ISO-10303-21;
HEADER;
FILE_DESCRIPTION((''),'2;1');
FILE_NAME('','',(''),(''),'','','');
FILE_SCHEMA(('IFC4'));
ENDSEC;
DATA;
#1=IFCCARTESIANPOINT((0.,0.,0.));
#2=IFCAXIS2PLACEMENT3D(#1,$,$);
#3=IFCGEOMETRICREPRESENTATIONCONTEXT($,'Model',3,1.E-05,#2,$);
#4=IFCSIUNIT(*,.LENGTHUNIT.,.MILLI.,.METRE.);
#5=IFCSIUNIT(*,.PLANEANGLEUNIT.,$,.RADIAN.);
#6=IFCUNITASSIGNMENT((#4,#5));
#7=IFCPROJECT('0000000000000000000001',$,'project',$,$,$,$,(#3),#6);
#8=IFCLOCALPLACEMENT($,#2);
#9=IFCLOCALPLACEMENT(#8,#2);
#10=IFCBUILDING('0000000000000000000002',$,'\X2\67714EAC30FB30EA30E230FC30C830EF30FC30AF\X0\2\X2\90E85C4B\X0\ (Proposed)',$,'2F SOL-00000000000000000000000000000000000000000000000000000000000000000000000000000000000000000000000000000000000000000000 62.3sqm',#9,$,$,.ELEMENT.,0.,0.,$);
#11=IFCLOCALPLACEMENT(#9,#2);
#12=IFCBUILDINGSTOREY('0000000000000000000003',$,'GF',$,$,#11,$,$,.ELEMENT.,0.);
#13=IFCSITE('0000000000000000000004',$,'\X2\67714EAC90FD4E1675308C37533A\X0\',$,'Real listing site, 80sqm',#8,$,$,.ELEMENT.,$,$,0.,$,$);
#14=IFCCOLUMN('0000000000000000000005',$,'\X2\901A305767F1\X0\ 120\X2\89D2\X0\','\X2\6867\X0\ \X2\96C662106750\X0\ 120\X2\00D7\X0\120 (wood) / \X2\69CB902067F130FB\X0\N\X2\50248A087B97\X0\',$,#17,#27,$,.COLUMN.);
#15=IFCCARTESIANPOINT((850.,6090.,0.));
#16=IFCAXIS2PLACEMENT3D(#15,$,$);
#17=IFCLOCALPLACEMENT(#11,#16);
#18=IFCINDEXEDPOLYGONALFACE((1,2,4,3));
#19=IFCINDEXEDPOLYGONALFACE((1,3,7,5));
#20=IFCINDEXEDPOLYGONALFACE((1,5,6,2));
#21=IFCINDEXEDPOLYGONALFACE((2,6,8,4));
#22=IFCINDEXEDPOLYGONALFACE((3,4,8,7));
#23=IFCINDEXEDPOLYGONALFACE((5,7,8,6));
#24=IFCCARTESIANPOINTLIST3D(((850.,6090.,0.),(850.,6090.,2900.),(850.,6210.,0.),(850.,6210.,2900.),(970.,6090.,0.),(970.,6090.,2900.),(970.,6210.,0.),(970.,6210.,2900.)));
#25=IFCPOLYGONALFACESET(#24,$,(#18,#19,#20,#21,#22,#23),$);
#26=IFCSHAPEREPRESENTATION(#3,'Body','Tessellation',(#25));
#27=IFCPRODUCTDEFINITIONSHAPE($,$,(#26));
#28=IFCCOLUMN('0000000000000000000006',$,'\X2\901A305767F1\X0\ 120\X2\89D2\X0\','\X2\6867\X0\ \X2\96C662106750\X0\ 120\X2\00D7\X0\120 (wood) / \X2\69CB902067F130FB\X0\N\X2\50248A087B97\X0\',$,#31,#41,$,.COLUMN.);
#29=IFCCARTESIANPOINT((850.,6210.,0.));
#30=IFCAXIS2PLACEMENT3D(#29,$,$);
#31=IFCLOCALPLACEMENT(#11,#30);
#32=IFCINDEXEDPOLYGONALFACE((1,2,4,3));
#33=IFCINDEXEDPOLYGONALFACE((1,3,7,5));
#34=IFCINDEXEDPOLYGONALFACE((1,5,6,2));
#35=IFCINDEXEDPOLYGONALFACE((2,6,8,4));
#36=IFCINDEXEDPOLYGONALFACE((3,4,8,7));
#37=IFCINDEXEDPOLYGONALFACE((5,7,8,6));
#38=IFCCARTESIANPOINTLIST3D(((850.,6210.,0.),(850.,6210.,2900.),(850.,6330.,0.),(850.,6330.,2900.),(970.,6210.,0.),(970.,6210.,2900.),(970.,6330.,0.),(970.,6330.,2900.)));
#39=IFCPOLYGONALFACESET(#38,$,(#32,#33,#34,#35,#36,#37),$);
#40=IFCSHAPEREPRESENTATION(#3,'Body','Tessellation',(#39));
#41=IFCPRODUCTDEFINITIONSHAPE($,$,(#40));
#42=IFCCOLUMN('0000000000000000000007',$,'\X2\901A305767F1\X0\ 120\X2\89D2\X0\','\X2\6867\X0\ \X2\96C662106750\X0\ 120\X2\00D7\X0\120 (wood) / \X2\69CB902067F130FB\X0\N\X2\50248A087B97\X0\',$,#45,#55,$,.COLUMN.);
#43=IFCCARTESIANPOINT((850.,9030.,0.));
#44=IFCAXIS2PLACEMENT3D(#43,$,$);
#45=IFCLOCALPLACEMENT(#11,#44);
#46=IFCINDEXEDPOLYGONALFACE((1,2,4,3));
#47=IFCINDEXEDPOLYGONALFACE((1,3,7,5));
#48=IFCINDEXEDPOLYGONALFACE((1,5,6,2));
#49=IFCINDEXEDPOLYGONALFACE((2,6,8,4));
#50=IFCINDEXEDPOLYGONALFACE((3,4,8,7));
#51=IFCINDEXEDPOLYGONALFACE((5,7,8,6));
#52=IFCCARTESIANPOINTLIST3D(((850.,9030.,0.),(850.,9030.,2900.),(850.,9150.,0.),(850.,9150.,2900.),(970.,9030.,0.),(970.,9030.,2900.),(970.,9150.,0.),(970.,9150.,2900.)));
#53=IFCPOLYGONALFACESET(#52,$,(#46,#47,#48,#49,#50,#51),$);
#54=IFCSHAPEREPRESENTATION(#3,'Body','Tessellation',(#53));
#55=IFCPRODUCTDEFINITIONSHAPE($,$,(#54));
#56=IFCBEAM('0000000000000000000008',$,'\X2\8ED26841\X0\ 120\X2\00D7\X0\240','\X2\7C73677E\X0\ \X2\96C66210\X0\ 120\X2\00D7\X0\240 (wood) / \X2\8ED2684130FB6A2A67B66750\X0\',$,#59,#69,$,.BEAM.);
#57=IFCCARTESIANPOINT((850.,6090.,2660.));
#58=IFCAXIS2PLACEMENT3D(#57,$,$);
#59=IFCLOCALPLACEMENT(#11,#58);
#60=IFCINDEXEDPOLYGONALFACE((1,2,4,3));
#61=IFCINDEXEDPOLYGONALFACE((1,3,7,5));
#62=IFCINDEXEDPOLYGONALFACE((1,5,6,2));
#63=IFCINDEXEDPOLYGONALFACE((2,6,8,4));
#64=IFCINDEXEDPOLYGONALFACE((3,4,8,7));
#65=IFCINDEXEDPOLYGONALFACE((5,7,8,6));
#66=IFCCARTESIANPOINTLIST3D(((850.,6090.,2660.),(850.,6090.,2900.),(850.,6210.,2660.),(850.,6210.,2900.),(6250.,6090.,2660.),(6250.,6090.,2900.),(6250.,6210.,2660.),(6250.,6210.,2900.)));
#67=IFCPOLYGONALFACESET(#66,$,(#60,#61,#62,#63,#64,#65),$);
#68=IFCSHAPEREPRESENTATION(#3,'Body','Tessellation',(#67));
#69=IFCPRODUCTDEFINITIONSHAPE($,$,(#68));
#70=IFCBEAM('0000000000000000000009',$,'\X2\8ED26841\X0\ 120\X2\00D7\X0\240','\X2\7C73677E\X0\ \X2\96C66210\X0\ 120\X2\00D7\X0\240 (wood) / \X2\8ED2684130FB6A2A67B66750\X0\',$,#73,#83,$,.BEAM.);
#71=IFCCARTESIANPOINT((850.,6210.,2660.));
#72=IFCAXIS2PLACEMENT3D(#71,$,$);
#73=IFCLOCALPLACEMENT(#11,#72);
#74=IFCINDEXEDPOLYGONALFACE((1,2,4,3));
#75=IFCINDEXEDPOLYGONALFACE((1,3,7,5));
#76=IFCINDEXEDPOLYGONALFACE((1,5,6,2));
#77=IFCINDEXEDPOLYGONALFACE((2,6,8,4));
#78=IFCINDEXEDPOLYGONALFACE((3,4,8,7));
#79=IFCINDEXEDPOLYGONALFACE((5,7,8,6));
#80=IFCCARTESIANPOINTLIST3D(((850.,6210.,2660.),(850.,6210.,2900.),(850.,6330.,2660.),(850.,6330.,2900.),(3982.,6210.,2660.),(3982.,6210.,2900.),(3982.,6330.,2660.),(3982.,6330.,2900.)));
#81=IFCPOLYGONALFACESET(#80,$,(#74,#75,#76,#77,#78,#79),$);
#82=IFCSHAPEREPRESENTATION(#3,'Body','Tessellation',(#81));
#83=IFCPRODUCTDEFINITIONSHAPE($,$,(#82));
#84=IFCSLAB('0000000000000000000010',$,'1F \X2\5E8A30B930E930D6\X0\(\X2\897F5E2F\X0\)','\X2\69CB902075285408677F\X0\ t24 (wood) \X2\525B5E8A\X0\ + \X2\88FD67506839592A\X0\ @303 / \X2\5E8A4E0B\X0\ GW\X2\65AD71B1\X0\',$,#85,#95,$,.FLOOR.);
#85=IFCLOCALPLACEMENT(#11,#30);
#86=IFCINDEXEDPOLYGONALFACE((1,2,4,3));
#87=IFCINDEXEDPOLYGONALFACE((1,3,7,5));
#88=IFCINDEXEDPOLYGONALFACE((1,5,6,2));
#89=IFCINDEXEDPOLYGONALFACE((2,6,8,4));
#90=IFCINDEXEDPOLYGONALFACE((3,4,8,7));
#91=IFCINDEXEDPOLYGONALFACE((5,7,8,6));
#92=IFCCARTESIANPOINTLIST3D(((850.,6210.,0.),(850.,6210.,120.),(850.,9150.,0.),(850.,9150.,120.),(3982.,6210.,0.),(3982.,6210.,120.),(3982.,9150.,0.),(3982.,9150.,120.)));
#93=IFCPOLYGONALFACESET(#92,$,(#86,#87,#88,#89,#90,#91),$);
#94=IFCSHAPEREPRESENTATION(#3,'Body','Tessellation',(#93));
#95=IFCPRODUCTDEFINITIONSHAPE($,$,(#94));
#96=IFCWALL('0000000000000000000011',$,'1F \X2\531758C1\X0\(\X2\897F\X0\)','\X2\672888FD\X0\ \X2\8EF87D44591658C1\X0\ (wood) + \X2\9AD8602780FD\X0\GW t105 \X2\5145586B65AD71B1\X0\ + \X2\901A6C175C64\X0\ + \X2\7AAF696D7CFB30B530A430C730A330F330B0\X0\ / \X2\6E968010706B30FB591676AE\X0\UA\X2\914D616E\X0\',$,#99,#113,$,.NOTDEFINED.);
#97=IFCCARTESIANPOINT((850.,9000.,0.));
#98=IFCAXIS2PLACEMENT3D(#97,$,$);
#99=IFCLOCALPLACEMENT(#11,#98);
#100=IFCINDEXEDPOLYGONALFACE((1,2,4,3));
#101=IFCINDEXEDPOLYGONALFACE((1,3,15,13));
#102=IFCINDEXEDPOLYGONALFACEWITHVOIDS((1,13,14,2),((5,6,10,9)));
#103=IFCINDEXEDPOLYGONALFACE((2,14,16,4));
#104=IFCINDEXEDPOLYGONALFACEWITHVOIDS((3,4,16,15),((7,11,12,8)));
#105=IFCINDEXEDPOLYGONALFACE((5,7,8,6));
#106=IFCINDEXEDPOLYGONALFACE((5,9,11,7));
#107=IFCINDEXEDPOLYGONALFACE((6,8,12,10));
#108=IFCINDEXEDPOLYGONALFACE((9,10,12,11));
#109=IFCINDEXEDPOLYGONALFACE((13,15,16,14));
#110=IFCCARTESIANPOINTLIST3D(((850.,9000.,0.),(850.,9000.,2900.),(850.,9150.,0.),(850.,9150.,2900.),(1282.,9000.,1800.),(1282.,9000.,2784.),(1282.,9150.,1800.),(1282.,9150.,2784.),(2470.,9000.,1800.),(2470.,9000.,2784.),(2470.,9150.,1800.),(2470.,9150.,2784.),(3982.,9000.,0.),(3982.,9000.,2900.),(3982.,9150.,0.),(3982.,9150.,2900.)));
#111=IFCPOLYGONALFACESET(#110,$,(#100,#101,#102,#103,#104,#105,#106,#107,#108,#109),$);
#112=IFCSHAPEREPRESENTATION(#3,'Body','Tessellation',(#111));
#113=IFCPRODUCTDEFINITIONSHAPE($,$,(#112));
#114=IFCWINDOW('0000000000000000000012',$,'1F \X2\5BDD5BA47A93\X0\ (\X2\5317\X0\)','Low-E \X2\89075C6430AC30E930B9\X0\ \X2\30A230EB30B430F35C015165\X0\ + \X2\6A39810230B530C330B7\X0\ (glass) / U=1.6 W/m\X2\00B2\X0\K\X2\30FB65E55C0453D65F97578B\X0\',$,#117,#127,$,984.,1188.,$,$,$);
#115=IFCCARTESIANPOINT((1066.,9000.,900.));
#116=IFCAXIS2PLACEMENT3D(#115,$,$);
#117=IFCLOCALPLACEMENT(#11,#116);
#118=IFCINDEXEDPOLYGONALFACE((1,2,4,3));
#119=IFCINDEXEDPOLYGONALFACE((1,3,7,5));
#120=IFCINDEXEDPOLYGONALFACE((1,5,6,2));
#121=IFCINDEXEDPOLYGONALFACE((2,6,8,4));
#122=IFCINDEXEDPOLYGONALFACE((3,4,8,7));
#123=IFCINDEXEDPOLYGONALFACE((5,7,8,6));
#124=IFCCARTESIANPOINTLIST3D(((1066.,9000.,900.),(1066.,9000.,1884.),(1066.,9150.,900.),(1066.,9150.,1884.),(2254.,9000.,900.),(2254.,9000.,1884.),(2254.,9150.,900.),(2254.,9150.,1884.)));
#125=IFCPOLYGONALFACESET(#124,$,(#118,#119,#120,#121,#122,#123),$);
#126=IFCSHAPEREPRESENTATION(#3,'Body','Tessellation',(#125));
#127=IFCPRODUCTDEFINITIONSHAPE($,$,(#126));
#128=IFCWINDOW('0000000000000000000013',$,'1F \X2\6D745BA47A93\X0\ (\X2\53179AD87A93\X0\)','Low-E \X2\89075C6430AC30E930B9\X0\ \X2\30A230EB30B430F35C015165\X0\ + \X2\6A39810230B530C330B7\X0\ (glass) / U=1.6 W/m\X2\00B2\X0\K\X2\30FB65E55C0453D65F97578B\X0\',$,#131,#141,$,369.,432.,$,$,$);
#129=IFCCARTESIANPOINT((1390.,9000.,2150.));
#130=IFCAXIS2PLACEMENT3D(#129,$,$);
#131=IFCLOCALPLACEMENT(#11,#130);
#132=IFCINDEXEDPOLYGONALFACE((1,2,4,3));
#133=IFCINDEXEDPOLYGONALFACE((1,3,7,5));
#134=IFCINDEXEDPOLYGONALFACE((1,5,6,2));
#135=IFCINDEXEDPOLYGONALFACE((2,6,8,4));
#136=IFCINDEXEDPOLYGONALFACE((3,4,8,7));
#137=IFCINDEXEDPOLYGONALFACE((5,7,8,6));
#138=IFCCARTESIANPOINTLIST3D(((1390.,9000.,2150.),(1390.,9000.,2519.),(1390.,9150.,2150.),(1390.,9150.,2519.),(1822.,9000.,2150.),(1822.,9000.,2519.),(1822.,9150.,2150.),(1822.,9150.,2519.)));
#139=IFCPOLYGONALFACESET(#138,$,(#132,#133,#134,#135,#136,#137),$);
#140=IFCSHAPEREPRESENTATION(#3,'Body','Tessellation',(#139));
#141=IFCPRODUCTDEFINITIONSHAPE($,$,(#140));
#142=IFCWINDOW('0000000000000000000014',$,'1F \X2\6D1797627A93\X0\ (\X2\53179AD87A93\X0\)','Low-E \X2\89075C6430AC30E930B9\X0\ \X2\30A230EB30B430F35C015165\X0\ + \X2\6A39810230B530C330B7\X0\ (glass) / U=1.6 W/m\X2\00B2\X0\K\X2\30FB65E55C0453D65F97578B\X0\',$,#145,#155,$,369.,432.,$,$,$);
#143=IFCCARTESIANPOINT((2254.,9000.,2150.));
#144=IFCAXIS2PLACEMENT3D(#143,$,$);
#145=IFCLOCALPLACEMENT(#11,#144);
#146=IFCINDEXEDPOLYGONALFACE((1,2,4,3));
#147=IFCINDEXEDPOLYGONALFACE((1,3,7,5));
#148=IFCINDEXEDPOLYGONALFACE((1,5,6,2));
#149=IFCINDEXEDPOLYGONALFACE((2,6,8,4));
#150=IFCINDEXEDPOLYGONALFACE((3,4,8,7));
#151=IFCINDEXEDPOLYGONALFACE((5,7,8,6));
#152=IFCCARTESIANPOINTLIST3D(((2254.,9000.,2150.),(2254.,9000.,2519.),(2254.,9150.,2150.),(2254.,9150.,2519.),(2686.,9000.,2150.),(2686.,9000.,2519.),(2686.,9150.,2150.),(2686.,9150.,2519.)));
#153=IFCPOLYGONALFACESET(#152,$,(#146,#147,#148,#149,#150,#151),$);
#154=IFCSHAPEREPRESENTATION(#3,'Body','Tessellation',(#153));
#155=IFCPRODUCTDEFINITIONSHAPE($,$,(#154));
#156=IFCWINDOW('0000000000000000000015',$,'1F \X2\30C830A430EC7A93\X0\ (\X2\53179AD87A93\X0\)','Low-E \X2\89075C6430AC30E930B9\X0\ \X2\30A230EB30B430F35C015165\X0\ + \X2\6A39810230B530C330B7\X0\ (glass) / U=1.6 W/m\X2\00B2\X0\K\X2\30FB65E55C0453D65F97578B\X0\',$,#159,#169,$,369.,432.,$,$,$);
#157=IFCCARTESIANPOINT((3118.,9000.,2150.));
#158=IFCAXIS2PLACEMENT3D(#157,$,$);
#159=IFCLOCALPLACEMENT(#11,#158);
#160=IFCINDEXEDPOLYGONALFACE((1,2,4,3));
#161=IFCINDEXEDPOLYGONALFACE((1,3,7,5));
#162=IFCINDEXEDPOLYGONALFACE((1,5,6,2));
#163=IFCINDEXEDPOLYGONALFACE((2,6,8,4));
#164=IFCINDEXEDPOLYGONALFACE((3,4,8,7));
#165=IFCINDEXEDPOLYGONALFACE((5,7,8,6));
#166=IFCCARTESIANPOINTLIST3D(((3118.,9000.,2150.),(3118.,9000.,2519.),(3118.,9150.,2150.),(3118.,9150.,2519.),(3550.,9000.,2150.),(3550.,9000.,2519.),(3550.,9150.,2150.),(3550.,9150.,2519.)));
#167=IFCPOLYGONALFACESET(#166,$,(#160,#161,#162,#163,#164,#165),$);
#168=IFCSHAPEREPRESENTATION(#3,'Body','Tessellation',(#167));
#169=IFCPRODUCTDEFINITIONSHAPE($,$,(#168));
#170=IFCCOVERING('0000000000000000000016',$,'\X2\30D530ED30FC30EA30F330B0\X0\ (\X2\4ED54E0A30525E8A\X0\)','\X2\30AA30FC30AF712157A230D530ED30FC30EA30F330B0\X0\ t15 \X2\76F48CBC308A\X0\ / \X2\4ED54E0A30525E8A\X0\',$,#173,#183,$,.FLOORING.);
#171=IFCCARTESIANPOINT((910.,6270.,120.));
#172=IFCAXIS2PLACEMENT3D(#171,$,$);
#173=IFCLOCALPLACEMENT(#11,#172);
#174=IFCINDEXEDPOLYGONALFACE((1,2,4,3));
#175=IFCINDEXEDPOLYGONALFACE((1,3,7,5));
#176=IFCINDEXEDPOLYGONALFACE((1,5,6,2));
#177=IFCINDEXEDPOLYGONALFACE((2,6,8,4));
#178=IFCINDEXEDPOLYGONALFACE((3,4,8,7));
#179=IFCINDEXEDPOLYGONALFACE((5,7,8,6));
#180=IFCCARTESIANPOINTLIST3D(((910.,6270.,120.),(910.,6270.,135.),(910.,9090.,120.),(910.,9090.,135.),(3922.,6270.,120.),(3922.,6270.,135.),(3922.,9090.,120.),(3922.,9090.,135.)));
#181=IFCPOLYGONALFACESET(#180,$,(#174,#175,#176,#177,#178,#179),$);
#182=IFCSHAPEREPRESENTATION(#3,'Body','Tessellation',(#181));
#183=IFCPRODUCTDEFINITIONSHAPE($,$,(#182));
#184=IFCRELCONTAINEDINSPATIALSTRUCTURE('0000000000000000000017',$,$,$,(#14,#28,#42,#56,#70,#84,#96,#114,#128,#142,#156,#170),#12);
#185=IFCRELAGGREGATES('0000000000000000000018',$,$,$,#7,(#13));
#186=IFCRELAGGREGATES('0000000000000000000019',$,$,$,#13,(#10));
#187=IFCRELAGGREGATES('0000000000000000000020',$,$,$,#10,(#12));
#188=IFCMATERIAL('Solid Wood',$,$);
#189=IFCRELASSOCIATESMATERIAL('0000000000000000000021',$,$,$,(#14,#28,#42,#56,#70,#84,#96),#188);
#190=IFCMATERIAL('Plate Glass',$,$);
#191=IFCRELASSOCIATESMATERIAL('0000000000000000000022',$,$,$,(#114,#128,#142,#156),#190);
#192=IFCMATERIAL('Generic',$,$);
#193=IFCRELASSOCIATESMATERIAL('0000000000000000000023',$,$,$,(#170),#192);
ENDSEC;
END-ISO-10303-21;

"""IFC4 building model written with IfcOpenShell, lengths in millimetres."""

from ifc_helpers import new_model, si_unit, frame, frame_2d, origin, place, context, project, spatial, rectangle, extrude, material, element, fill, save


model = new_model("IFC4")

# Units and contexts
model_context = context("Model", 3, precision=1e-05, world=origin())
ifc_project = project(units=[si_unit("LENGTHUNIT", "METRE", prefix="MILLI"), si_unit("PLANEANGLEUNIT", "RADIAN")], contexts=[model_context])

# Site, building, storey
site_placement = place(None, origin())
site = spatial("IfcSite", under=ifc_project, at=site_placement, Name="東京都世田谷区", ObjectType="Real listing site, 80sqm", CompositionType="ELEMENT", RefElevation=0.0)
building_placement = place(site_placement, origin())
building = spatial("IfcBuilding", under=site, at=building_placement, Name="東京・リモートワーク2部屋 (Proposed)", ObjectType="2F SOL-00000000000000000000000000000000000000000000000000000000000000000000000000000000000000000000000000000000000000000000 62.3sqm", CompositionType="ELEMENT", ElevationOfRefHeight=0.0, ElevationOfTerrain=0.0)
storey_placement = place(building_placement, origin())
storey = spatial("IfcBuildingStorey", under=building, at=storey_placement, Name="GF", CompositionType="ELEMENT", Elevation=0.0)

# Columns
ifc_material_1 = material(Name="Solid Wood")
column_1_placement = place(storey_placement, frame((850.0, 6090.0, 0.0)))
element("IfcColumn", 1, at=column_1_placement, inside=storey, material=ifc_material_1, Name="通し柱 120角", Description="桧 集成材 120×120 (wood) / 構造柱・N値計算", PredefinedType="COLUMN", context=model_context, shape_type="SweptSolid", body=[
    extrude(rectangle(XDim=120.0, YDim=120.0, at=frame_2d((60.0, 60.0))), frame((850.0, 6090.0, 0.0)), (0.0, 0.0, 1.0), 2900.0),
])
column_2_placement = place(storey_placement, frame((850.0, 6210.0, 0.0)))
element("IfcColumn", 2, at=column_2_placement, inside=storey, material=ifc_material_1, Name="通し柱 120角", Description="桧 集成材 120×120 (wood) / 構造柱・N値計算", PredefinedType="COLUMN", context=model_context, shape_type="SweptSolid", body=[
    extrude(rectangle(XDim=120.0, YDim=120.0, at=frame_2d((60.0, 60.0))), frame((850.0, 6210.0, 0.0)), (0.0, 0.0, 1.0), 2900.0),
])
column_3_placement = place(storey_placement, frame((850.0, 9030.0, 0.0)))
element("IfcColumn", 3, at=column_3_placement, inside=storey, material=ifc_material_1, Name="通し柱 120角", Description="桧 集成材 120×120 (wood) / 構造柱・N値計算", PredefinedType="COLUMN", context=model_context, shape_type="SweptSolid", body=[
    extrude(rectangle(XDim=120.0, YDim=120.0, at=frame_2d((60.0, 60.0))), frame((850.0, 9030.0, 0.0)), (0.0, 0.0, 1.0), 2900.0),
])

# Beams
beam_1_placement = place(storey_placement, frame((850.0, 6090.0, 2660.0)))
element("IfcBeam", 4, at=beam_1_placement, inside=storey, material=ifc_material_1, Name="軒桁 120×240", Description="米松 集成 120×240 (wood) / 軒桁・横架材", PredefinedType="BEAM", context=model_context, shape_type="SweptSolid", body=[
    extrude(rectangle(XDim=5400.0, YDim=120.0, at=frame_2d((2700.0, 60.0))), frame((850.0, 6090.0, 2660.0)), (0.0, 0.0, 1.0), 240.0),
])
beam_2_placement = place(storey_placement, frame((850.0, 6210.0, 2660.0)))
element("IfcBeam", 5, at=beam_2_placement, inside=storey, material=ifc_material_1, Name="軒桁 120×240", Description="米松 集成 120×240 (wood) / 軒桁・横架材", PredefinedType="BEAM", context=model_context, shape_type="SweptSolid", body=[
    extrude(rectangle(XDim=3132.0, YDim=120.0, at=frame_2d((1566.0, 60.0))), frame((850.0, 6210.0, 2660.0)), (0.0, 0.0, 1.0), 240.0),
])

# Slab
slab_placement = place(storey_placement, frame((850.0, 6210.0, 0.0)))
element("IfcSlab", 6, at=slab_placement, inside=storey, material=ifc_material_1, Name="1F 床スラブ(西帯)", Description="構造用合板 t24 (wood) 剛床 + 製材根太 @303 / 床下 GW断熱", PredefinedType="FLOOR", context=model_context, shape_type="SweptSolid", body=[
    extrude(rectangle(XDim=3132.0, YDim=2940.0, at=frame_2d((1566.0, 1470.0))), frame((850.0, 6210.0, 0.0)), (0.0, 0.0, 1.0), 120.0),
])

# Wall, openings, windows
wall_1_placement = place(storey_placement, frame((850.0, 9000.0, 0.0)))
wall_1 = element("IfcWall", 7, at=wall_1_placement, inside=storey, material=ifc_material_1, Name="1F 北壁(西)", Description="木製 軸組外壁 (wood) + 高性能GW t105 充填断熱 + 通気層 + 窯業系サイディング / 準耐火・外皮UA配慮", PredefinedType="NOTDEFINED", context=model_context, shape_type="SweptSolid", body=[
    extrude(rectangle(XDim=3132.0, YDim=150.0, at=frame_2d((1566.0, 75.0))), frame((850.0, 9000.0, 0.0)), (0.0, 0.0, 1.0), 2900.0),
])
opening_1_placement = place(storey_placement, frame((1066.0, 9000.0, 900.0)))
opening_1 = element("IfcOpeningElement", 8, at=opening_1_placement, cuts=wall_1, PredefinedType="NOTDEFINED", context=model_context, shape_type="SweptSolid", body=[
    extrude(rectangle(XDim=1188.0, YDim=150.0, at=frame_2d((594.0, 75.0))), frame((1066.0, 9000.0, 900.0)), (0.0, 0.0, 1.0), 984.0),
])
opening_2_placement = place(storey_placement, frame((1390.0, 9000.0, 2150.0)))
opening_2 = element("IfcOpeningElement", 9, at=opening_2_placement, cuts=wall_1, PredefinedType="NOTDEFINED", context=model_context, shape_type="SweptSolid", body=[
    extrude(rectangle(XDim=432.0, YDim=150.0, at=frame_2d((216.0, 75.0))), frame((1390.0, 9000.0, 2150.0)), (0.0, 0.0, 1.0), 369.0),
])
opening_3_placement = place(storey_placement, frame((2254.0, 9000.0, 2150.0)))
opening_3 = element("IfcOpeningElement", 10, at=opening_3_placement, cuts=wall_1, PredefinedType="NOTDEFINED", context=model_context, shape_type="SweptSolid", body=[
    extrude(rectangle(XDim=432.0, YDim=150.0, at=frame_2d((216.0, 75.0))), frame((2254.0, 9000.0, 2150.0)), (0.0, 0.0, 1.0), 369.0),
])
opening_4_placement = place(storey_placement, frame((3118.0, 9000.0, 2150.0)))
opening_4 = element("IfcOpeningElement", 11, at=opening_4_placement, cuts=wall_1, PredefinedType="NOTDEFINED", context=model_context, shape_type="SweptSolid", body=[
    extrude(rectangle(XDim=432.0, YDim=150.0, at=frame_2d((216.0, 75.0))), frame((3118.0, 9000.0, 2150.0)), (0.0, 0.0, 1.0), 369.0),
])
ifc_material_2 = material(Name="Plate Glass")
window_1_placement = place(storey_placement, frame((1066.0, 9000.0, 900.0)))
window_1 = element("IfcWindow", 12, at=window_1_placement, inside=storey, material=ifc_material_2, Name="1F 寝室窓 (北)", Description="Low-E 複層ガラス アルゴン封入 + 樹脂サッシ (glass) / U=1.6 W/m²K・日射取得型", OverallHeight=984.0, OverallWidth=1188.0, context=model_context, shape_type="SweptSolid", body=[
    extrude(rectangle(XDim=1188.0, YDim=150.0, at=frame_2d((594.0, 75.0))), frame((1066.0, 9000.0, 900.0)), (0.0, 0.0, 1.0), 984.0),
])
fill(opening_1, window_1)
window_2_placement = place(storey_placement, frame((1390.0, 9000.0, 2150.0)))
window_2 = element("IfcWindow", 13, at=window_2_placement, inside=storey, material=ifc_material_2, Name="1F 浴室窓 (北高窓)", Description="Low-E 複層ガラス アルゴン封入 + 樹脂サッシ (glass) / U=1.6 W/m²K・日射取得型", OverallHeight=369.0, OverallWidth=432.0, context=model_context, shape_type="SweptSolid", body=[
    extrude(rectangle(XDim=432.0, YDim=150.0, at=frame_2d((216.0, 75.0))), frame((1390.0, 9000.0, 2150.0)), (0.0, 0.0, 1.0), 369.0),
])
fill(opening_2, window_2)
window_3_placement = place(storey_placement, frame((2254.0, 9000.0, 2150.0)))
window_3 = element("IfcWindow", 14, at=window_3_placement, inside=storey, material=ifc_material_2, Name="1F 洗面窓 (北高窓)", Description="Low-E 複層ガラス アルゴン封入 + 樹脂サッシ (glass) / U=1.6 W/m²K・日射取得型", OverallHeight=369.0, OverallWidth=432.0, context=model_context, shape_type="SweptSolid", body=[
    extrude(rectangle(XDim=432.0, YDim=150.0, at=frame_2d((216.0, 75.0))), frame((2254.0, 9000.0, 2150.0)), (0.0, 0.0, 1.0), 369.0),
])
fill(opening_3, window_3)
window_4_placement = place(storey_placement, frame((3118.0, 9000.0, 2150.0)))
window_4 = element("IfcWindow", 15, at=window_4_placement, inside=storey, material=ifc_material_2, Name="1F トイレ窓 (北高窓)", Description="Low-E 複層ガラス アルゴン封入 + 樹脂サッシ (glass) / U=1.6 W/m²K・日射取得型", OverallHeight=369.0, OverallWidth=432.0, context=model_context, shape_type="SweptSolid", body=[
    extrude(rectangle(XDim=432.0, YDim=150.0, at=frame_2d((216.0, 75.0))), frame((3118.0, 9000.0, 2150.0)), (0.0, 0.0, 1.0), 369.0),
])
fill(opening_4, window_4)

# Covering
ifc_material_3 = material(Name="Generic")
covering_placement = place(storey_placement, frame((910.0, 6270.0, 120.0)))
element("IfcCovering", 16, at=covering_placement, inside=storey, material=ifc_material_3, Name="フローリング (仕上げ床)", Description="オーク無垢フローリング t15 直貼り / 仕上げ床", PredefinedType="FLOORING", context=model_context, shape_type="SweptSolid", body=[
    extrude(rectangle(XDim=3012.0, YDim=2820.0, at=frame_2d((1506.0, 1410.0))), frame((910.0, 6270.0, 120.0)), (0.0, 0.0, 1.0), 15.0),
])

save(model, "model.ifc")
